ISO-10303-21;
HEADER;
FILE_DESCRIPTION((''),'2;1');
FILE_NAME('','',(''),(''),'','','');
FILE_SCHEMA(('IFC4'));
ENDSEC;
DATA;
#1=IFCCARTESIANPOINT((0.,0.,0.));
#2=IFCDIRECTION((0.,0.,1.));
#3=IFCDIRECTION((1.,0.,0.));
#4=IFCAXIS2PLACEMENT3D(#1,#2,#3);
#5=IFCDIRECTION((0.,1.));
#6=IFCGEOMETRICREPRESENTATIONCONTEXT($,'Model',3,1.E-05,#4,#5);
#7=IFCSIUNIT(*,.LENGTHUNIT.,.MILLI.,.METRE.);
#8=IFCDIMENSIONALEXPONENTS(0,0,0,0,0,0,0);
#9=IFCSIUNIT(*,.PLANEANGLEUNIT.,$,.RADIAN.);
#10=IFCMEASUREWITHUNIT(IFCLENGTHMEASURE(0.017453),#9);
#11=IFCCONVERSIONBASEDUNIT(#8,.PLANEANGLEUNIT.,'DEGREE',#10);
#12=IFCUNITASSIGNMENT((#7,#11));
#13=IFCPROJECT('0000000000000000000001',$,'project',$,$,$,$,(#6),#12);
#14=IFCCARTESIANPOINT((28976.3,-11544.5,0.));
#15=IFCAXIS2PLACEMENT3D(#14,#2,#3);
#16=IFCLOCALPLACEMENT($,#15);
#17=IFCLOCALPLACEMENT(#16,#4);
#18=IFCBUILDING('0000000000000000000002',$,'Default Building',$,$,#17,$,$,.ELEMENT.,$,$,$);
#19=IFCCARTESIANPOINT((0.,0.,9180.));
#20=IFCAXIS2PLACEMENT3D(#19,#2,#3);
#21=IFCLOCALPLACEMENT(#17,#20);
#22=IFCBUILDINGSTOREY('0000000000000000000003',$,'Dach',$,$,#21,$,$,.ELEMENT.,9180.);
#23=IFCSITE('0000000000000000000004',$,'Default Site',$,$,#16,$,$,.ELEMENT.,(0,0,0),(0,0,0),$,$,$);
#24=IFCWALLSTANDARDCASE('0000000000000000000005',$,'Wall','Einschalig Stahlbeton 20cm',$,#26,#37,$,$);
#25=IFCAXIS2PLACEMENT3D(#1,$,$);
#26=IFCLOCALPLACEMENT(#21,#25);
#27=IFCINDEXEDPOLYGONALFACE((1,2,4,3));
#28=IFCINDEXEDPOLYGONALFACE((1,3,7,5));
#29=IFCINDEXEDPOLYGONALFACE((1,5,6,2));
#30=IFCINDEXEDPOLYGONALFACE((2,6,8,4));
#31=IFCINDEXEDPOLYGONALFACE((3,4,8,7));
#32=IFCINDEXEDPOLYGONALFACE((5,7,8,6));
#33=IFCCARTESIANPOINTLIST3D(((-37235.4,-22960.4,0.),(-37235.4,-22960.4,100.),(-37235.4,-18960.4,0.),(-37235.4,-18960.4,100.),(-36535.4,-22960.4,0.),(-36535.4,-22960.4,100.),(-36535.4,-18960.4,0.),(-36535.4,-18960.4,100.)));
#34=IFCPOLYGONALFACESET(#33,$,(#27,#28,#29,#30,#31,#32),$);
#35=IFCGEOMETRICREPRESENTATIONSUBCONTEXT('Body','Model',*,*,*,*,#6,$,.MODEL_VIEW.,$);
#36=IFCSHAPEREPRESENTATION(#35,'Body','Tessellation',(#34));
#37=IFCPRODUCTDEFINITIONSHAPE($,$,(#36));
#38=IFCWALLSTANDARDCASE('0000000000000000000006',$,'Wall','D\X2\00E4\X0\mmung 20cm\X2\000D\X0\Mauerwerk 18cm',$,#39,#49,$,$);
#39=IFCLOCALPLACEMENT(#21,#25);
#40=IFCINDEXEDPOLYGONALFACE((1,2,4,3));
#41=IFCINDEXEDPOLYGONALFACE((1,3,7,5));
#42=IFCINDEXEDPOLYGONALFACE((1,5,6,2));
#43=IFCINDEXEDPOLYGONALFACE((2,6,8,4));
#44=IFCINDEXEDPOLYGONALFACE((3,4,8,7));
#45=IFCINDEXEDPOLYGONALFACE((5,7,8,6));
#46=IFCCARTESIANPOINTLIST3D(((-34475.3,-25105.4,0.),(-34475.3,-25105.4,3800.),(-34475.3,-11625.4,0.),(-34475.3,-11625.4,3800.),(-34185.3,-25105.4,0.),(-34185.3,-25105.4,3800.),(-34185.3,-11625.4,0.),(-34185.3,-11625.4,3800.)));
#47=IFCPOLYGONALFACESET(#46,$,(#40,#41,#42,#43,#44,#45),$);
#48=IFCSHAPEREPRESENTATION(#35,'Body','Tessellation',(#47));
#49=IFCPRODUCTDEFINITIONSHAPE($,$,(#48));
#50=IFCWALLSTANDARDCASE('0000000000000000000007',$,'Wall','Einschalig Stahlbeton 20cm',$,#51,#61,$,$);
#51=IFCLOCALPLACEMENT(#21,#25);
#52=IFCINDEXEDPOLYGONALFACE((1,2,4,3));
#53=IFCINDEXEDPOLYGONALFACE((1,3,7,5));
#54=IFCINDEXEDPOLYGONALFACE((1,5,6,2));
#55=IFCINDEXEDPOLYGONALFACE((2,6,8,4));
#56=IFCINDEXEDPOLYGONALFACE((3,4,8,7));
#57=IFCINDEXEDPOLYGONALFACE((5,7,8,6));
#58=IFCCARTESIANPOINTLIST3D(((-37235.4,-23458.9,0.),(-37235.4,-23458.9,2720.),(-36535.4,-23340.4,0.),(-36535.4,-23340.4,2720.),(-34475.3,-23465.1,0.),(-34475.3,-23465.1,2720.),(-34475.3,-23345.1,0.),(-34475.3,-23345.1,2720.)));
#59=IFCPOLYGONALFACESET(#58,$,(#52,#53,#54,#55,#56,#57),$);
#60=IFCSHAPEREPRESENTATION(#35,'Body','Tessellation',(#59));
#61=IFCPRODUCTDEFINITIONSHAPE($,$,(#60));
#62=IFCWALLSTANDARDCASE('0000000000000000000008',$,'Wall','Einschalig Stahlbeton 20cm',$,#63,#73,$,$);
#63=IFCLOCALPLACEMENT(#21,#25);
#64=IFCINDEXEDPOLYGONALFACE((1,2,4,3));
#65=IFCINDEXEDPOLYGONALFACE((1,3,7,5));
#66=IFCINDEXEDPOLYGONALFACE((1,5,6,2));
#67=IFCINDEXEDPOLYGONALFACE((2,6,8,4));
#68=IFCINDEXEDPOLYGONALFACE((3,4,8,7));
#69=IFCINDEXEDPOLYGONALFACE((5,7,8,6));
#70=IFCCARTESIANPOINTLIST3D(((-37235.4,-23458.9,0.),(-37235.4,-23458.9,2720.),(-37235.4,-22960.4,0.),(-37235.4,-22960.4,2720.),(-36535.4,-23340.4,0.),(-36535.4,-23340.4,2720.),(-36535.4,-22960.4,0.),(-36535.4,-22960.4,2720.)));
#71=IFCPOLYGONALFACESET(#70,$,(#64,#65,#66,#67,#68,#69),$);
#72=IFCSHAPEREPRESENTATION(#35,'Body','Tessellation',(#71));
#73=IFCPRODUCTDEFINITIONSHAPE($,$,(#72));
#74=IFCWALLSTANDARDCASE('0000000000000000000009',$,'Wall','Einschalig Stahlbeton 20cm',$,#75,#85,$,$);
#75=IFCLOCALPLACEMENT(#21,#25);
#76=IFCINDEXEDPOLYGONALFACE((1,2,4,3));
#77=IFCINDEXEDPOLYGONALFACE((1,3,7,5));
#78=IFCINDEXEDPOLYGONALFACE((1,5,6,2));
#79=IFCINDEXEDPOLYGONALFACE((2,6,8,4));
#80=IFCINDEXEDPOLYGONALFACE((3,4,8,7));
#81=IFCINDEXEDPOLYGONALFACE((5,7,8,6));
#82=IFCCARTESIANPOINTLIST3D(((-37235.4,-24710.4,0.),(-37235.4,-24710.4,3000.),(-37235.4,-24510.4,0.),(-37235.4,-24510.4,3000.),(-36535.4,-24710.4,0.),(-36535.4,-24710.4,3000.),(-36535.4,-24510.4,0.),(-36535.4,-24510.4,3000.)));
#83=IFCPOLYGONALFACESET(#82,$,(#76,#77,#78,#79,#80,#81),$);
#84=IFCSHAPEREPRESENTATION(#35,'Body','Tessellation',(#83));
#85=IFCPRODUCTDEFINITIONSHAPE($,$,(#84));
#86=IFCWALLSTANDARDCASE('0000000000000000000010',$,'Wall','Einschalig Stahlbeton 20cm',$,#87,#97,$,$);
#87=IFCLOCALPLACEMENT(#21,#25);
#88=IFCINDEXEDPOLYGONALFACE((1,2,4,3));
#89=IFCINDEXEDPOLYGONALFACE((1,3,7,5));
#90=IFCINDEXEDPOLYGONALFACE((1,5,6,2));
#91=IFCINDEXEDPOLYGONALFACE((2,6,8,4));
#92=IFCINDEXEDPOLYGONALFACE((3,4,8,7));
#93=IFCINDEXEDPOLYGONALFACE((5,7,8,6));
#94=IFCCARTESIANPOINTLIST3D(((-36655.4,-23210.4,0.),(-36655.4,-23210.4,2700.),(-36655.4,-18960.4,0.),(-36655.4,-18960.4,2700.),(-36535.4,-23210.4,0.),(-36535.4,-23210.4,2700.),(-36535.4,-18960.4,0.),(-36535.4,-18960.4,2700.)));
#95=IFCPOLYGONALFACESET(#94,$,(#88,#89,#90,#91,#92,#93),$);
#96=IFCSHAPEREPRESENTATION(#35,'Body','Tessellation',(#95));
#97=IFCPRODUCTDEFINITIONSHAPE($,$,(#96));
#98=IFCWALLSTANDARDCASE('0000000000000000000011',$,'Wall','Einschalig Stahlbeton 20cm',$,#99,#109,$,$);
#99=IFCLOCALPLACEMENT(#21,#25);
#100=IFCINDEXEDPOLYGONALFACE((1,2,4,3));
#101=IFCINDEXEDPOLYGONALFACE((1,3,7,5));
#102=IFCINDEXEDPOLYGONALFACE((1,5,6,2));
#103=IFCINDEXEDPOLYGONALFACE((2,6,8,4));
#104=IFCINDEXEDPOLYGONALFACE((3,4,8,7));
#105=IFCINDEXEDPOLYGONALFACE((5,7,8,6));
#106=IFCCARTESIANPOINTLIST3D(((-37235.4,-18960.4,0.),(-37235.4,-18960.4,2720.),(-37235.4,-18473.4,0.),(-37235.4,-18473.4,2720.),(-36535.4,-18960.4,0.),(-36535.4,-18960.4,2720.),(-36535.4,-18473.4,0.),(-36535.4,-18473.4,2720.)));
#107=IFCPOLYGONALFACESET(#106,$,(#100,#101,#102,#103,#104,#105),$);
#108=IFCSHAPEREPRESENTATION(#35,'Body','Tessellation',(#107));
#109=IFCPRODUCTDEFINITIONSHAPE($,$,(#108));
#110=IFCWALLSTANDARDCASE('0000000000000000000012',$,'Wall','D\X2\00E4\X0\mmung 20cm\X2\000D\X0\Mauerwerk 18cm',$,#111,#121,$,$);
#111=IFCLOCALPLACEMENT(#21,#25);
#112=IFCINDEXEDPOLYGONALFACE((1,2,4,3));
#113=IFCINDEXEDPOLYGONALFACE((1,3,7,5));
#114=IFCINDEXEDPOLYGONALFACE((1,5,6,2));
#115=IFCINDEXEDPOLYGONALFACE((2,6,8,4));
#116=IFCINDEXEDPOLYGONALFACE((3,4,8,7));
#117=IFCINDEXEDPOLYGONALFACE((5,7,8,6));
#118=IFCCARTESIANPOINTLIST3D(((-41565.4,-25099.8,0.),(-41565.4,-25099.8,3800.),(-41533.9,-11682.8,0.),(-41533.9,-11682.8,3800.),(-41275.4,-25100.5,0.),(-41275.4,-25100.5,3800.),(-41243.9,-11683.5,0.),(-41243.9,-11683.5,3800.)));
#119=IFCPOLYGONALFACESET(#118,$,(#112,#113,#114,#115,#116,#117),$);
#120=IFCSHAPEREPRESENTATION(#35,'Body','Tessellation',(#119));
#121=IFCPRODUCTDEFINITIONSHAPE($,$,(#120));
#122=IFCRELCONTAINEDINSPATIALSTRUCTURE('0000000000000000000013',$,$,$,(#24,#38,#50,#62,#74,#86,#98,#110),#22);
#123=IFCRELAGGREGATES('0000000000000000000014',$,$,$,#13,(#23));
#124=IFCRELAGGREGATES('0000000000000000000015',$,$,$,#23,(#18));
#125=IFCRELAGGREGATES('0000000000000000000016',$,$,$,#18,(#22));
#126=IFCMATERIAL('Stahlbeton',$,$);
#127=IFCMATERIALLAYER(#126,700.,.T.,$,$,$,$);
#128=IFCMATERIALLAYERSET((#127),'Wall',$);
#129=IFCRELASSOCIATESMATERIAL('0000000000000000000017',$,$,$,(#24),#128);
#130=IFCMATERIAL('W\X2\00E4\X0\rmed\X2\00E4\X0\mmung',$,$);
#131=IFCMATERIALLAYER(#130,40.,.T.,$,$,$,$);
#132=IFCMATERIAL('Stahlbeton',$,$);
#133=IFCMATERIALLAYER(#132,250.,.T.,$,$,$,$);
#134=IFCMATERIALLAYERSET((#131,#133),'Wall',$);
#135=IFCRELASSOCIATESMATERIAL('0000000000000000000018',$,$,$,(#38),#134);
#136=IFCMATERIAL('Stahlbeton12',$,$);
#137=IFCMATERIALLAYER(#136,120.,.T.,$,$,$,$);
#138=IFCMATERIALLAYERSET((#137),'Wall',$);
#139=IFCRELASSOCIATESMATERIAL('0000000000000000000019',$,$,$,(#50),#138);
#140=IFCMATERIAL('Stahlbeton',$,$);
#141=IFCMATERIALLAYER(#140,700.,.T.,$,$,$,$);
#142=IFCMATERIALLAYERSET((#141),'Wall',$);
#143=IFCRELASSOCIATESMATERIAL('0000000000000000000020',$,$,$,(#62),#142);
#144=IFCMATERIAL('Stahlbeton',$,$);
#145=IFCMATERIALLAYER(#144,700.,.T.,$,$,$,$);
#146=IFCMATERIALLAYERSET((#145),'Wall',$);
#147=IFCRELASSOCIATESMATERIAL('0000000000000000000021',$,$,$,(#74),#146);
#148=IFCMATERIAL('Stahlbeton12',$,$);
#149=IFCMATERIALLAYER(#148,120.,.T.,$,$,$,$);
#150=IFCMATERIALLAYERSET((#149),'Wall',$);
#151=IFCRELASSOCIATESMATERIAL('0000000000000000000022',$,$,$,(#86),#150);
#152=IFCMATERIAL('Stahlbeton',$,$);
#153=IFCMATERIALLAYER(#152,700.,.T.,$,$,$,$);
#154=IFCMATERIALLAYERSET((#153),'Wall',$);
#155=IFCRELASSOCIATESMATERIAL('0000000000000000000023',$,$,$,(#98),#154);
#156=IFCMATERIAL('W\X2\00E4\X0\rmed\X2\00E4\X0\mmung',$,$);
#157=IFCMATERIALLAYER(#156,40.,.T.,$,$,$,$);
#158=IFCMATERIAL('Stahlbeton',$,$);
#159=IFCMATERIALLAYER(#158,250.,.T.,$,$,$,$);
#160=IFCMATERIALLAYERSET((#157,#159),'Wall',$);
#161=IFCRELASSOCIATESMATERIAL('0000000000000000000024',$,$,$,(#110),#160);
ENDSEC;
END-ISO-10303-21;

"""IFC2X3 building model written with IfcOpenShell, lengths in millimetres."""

from ifc_helpers import new_model, entity, si_unit, converted_unit, direction, frame, origin_with_axes, place, context, subcontext, project, spatial, polyline, outline, extrude, material, layer, layer_set, layer_usage, element, save


model = new_model("IFC2X3")

# Units and contexts
model_context = context("Model", 3, precision=1e-05, world=origin_with_axes(), true_north=direction((0.0, 1.0)))
body_context = subcontext(model_context, "Body", "Model", "MODEL_VIEW")
ifc_project = project(units=[si_unit("LENGTHUNIT", "METRE", prefix="MILLI"), converted_unit("PLANEANGLEUNIT", "DEGREE", entity("IfcLengthMeasure", 0.017453), si_unit("PLANEANGLEUNIT", "RADIAN"), dimensions=[0, 0, 0, 0, 0, 0, 0])], contexts=[model_context])

# Site, building, storey
site_placement = place(None, frame((28976.3, -11544.5, 0.0), z_axis=(0.0, 0.0, 1.0), x_axis=(1.0, 0.0, 0.0)))
site = spatial("IfcSite", under=ifc_project, at=site_placement, Name="Default Site", CompositionType="ELEMENT", RefLatitude=(0, 0, 0), RefLongitude=(0, 0, 0))
building_placement = place(site_placement, origin_with_axes())
building = spatial("IfcBuilding", under=site, at=building_placement, Name="Default Building", CompositionType="ELEMENT")
storey_placement = place(building_placement, frame((0.0, 0.0, 9180.0), z_axis=(0.0, 0.0, 1.0), x_axis=(1.0, 0.0, 0.0)))
storey = spatial("IfcBuildingStorey", under=building, at=storey_placement, Name="Dach", CompositionType="ELEMENT", Elevation=9180.0)

# Walls
ifc_material_1 = material(Name="Stahlbeton")
ifc_layer_1 = layer(ifc_material_1, 700.0, ventilated=True)
ifc_layer_set_1 = layer_set([ifc_layer_1], Name="Wall")
ifc_layer_usage_1 = layer_usage(ifc_layer_set_1, "AXIS2", "POSITIVE", -350.0)
wall_1_placement = place(storey_placement, frame((-36885.4, -18960.4, 0.0), z_axis=(0.0, 0.0, 1.0), x_axis=(0.0, -1.0, 0.0)))
element("IfcWallStandardCase", 1, at=wall_1_placement, inside=storey, material=ifc_layer_usage_1, Name="Wall", Description="Einschalig Stahlbeton 20cm", context=body_context, shape_type="SweptSolid", body=[
    extrude(outline(polyline([(0.0, -350.0), (0.0, 350.0), (4000.0, 350.0), (4000.0, -350.0), (0.0, -350.0)])), origin_with_axes(), (0.0, 0.0, 1.0), 100.0),
])
ifc_material_2 = material(Name="Wärmedämmung")
ifc_layer_2 = layer(ifc_material_2, 40.0, ventilated=True)
ifc_material_3 = material(Name="Stahlbeton")
ifc_layer_3 = layer(ifc_material_3, 250.0, ventilated=True)
ifc_layer_set_2 = layer_set([ifc_layer_2, ifc_layer_3], Name="Wall")
ifc_layer_usage_2 = layer_usage(ifc_layer_set_2, "AXIS2", "POSITIVE", -145.0)
wall_2_placement = place(storey_placement, frame((-34330.3, -11625.4, 0.0), z_axis=(0.0, 0.0, 1.0), x_axis=(0.0, -1.0, 0.0)))
element("IfcWallStandardCase", 2, at=wall_2_placement, inside=storey, material=ifc_layer_usage_2, Name="Wall", Description="Dämmung 20cm\rMauerwerk 18cm", context=body_context, shape_type="SweptSolid", body=[
    extrude(outline(polyline([(0.0, -145.0), (0.0, 145.0), (13480.0, 145.0), (13480.0, -145.0), (0.0, -145.0)])), origin_with_axes(), (0.0, 0.0, 1.0), 3800.0),
])
ifc_material_4 = material(Name="Stahlbeton12")
ifc_layer_4 = layer(ifc_material_4, 120.0, ventilated=True)
ifc_layer_set_3 = layer_set([ifc_layer_4], Name="Wall")
ifc_layer_usage_3 = layer_usage(ifc_layer_set_3, "AXIS2", "POSITIVE", -60.0)
wall_3_placement = place(storey_placement, frame((-36885.4, -23399.6, 0.0), z_axis=(0.0, 0.0, 1.0), x_axis=(0.999997, -0.002241, 0.0)))
element("IfcWallStandardCase", 3, at=wall_3_placement, inside=storey, material=ifc_layer_usage_3, Name="Wall", Description="Einschalig Stahlbeton 20cm", context=body_context, shape_type="SweptSolid", body=[
    extrude(outline(polyline([(2410.2, -60.0), (2409.9, 60.0), (349.9, 60.0), (-349.9, -60.0), (2410.2, -60.0)])), origin_with_axes(), (0.0, 0.0, 1.0), 2720.0),
])
ifc_material_5 = material(Name="Stahlbeton")
ifc_layer_5 = layer(ifc_material_5, 700.0, ventilated=True)
ifc_layer_set_4 = layer_set([ifc_layer_5], Name="Wall")
ifc_layer_usage_4 = layer_usage(ifc_layer_set_4, "AXIS2", "POSITIVE", -350.0)
wall_4_placement = place(storey_placement, frame((-36885.4, -22960.4, 0.0), z_axis=(0.0, 0.0, 1.0), x_axis=(0.0, -1.0, 0.0)))
element("IfcWallStandardCase", 4, at=wall_4_placement, inside=storey, material=ifc_layer_usage_4, Name="Wall", Description="Einschalig Stahlbeton 20cm", context=body_context, shape_type="SweptSolid", body=[
    extrude(outline(polyline([(498.4, -350.0), (380.0, 350.0), (0.0, 350.0), (0.0, -350.0), (498.4, -350.0)])), origin_with_axes(), (0.0, 0.0, 1.0), 2720.0),
])
ifc_material_6 = material(Name="Stahlbeton")
ifc_layer_6 = layer(ifc_material_6, 700.0, ventilated=True)
ifc_layer_set_5 = layer_set([ifc_layer_6], Name="Wall")
ifc_layer_usage_5 = layer_usage(ifc_layer_set_5, "AXIS2", "POSITIVE", -350.0)
wall_5_placement = place(storey_placement, frame((-36885.4, -24510.4, 0.0), z_axis=(0.0, 0.0, 1.0), x_axis=(0.000004, -1.0, 0.0)))
element("IfcWallStandardCase", 5, at=wall_5_placement, inside=storey, material=ifc_layer_usage_5, Name="Wall", Description="Einschalig Stahlbeton 20cm", context=body_context, shape_type="SweptSolid", body=[
    extrude(outline(polyline([(0.0, -350.0), (0.0, 350.0), (200.0, 350.0), (200.0, -350.0), (0.0, -350.0)])), origin_with_axes(), (0.0, 0.0, 1.0), 3000.0),
])
ifc_material_7 = material(Name="Stahlbeton12")
ifc_layer_7 = layer(ifc_material_7, 120.0, ventilated=True)
ifc_layer_set_6 = layer_set([ifc_layer_7], Name="Wall")
ifc_layer_usage_6 = layer_usage(ifc_layer_set_6, "AXIS2", "POSITIVE", -60.0)
wall_6_placement = place(storey_placement, frame((-36595.4, -18960.4, 0.0), z_axis=(0.0, 0.0, 1.0), x_axis=(0.0, -1.0, 0.0)))
element("IfcWallStandardCase", 6, at=wall_6_placement, inside=storey, material=ifc_layer_usage_6, Name="Wall", Description="Einschalig Stahlbeton 20cm", context=body_context, shape_type="SweptSolid", body=[
    extrude(outline(polyline([(0.0, -60.0), (0.0, 60.0), (4250.0, 60.0), (4250.0, -60.0), (0.0, -60.0)])), origin_with_axes(), (0.0, 0.0, 1.0), 2700.0),
])
ifc_material_8 = material(Name="Stahlbeton")
ifc_layer_8 = layer(ifc_material_8, 700.0, ventilated=True)
ifc_layer_set_7 = layer_set([ifc_layer_8], Name="Wall")
ifc_layer_usage_7 = layer_usage(ifc_layer_set_7, "AXIS2", "POSITIVE", -350.0)
wall_7_placement = place(storey_placement, frame((-36885.4, -18473.4, 0.0), z_axis=(0.0, 0.0, 1.0), x_axis=(0.0, -1.0, 0.0)))
element("IfcWallStandardCase", 7, at=wall_7_placement, inside=storey, material=ifc_layer_usage_7, Name="Wall", Description="Einschalig Stahlbeton 20cm", context=body_context, shape_type="SweptSolid", body=[
    extrude(outline(polyline([(0.0, -350.0), (0.0, 350.0), (487.1, 350.0), (487.1, -350.0), (0.0, -350.0)])), origin_with_axes(), (0.0, 0.0, 1.0), 2720.0),
])
ifc_material_9 = material(Name="Wärmedämmung")
ifc_layer_9 = layer(ifc_material_9, 40.0, ventilated=True)
ifc_material_10 = material(Name="Stahlbeton")
ifc_layer_10 = layer(ifc_material_10, 250.0, ventilated=True)
ifc_layer_set_8 = layer_set([ifc_layer_9, ifc_layer_10], Name="Wall")
ifc_layer_usage_8 = layer_usage(ifc_layer_set_8, "AXIS2", "POSITIVE", -145.0)
wall_8_placement = place(storey_placement, frame((-41420.4, -25100.1, 0.0), z_axis=(0.0, 0.0, 1.0), x_axis=(0.002348, 0.999997, 0.0)))
element("IfcWallStandardCase", 8, at=wall_8_placement, inside=storey, material=ifc_layer_usage_8, Name="Wall", Description="Dämmung 20cm\rMauerwerk 18cm", context=body_context, shape_type="SweptSolid", body=[
    extrude(outline(polyline([(0.0, -145.0), (0.0, 145.0), (13417.0, 145.0), (13417.0, -145.0), (0.0, -145.0)])), origin_with_axes(), (0.0, 0.0, 1.0), 3800.0),
])

save(model, "model.ifc")
